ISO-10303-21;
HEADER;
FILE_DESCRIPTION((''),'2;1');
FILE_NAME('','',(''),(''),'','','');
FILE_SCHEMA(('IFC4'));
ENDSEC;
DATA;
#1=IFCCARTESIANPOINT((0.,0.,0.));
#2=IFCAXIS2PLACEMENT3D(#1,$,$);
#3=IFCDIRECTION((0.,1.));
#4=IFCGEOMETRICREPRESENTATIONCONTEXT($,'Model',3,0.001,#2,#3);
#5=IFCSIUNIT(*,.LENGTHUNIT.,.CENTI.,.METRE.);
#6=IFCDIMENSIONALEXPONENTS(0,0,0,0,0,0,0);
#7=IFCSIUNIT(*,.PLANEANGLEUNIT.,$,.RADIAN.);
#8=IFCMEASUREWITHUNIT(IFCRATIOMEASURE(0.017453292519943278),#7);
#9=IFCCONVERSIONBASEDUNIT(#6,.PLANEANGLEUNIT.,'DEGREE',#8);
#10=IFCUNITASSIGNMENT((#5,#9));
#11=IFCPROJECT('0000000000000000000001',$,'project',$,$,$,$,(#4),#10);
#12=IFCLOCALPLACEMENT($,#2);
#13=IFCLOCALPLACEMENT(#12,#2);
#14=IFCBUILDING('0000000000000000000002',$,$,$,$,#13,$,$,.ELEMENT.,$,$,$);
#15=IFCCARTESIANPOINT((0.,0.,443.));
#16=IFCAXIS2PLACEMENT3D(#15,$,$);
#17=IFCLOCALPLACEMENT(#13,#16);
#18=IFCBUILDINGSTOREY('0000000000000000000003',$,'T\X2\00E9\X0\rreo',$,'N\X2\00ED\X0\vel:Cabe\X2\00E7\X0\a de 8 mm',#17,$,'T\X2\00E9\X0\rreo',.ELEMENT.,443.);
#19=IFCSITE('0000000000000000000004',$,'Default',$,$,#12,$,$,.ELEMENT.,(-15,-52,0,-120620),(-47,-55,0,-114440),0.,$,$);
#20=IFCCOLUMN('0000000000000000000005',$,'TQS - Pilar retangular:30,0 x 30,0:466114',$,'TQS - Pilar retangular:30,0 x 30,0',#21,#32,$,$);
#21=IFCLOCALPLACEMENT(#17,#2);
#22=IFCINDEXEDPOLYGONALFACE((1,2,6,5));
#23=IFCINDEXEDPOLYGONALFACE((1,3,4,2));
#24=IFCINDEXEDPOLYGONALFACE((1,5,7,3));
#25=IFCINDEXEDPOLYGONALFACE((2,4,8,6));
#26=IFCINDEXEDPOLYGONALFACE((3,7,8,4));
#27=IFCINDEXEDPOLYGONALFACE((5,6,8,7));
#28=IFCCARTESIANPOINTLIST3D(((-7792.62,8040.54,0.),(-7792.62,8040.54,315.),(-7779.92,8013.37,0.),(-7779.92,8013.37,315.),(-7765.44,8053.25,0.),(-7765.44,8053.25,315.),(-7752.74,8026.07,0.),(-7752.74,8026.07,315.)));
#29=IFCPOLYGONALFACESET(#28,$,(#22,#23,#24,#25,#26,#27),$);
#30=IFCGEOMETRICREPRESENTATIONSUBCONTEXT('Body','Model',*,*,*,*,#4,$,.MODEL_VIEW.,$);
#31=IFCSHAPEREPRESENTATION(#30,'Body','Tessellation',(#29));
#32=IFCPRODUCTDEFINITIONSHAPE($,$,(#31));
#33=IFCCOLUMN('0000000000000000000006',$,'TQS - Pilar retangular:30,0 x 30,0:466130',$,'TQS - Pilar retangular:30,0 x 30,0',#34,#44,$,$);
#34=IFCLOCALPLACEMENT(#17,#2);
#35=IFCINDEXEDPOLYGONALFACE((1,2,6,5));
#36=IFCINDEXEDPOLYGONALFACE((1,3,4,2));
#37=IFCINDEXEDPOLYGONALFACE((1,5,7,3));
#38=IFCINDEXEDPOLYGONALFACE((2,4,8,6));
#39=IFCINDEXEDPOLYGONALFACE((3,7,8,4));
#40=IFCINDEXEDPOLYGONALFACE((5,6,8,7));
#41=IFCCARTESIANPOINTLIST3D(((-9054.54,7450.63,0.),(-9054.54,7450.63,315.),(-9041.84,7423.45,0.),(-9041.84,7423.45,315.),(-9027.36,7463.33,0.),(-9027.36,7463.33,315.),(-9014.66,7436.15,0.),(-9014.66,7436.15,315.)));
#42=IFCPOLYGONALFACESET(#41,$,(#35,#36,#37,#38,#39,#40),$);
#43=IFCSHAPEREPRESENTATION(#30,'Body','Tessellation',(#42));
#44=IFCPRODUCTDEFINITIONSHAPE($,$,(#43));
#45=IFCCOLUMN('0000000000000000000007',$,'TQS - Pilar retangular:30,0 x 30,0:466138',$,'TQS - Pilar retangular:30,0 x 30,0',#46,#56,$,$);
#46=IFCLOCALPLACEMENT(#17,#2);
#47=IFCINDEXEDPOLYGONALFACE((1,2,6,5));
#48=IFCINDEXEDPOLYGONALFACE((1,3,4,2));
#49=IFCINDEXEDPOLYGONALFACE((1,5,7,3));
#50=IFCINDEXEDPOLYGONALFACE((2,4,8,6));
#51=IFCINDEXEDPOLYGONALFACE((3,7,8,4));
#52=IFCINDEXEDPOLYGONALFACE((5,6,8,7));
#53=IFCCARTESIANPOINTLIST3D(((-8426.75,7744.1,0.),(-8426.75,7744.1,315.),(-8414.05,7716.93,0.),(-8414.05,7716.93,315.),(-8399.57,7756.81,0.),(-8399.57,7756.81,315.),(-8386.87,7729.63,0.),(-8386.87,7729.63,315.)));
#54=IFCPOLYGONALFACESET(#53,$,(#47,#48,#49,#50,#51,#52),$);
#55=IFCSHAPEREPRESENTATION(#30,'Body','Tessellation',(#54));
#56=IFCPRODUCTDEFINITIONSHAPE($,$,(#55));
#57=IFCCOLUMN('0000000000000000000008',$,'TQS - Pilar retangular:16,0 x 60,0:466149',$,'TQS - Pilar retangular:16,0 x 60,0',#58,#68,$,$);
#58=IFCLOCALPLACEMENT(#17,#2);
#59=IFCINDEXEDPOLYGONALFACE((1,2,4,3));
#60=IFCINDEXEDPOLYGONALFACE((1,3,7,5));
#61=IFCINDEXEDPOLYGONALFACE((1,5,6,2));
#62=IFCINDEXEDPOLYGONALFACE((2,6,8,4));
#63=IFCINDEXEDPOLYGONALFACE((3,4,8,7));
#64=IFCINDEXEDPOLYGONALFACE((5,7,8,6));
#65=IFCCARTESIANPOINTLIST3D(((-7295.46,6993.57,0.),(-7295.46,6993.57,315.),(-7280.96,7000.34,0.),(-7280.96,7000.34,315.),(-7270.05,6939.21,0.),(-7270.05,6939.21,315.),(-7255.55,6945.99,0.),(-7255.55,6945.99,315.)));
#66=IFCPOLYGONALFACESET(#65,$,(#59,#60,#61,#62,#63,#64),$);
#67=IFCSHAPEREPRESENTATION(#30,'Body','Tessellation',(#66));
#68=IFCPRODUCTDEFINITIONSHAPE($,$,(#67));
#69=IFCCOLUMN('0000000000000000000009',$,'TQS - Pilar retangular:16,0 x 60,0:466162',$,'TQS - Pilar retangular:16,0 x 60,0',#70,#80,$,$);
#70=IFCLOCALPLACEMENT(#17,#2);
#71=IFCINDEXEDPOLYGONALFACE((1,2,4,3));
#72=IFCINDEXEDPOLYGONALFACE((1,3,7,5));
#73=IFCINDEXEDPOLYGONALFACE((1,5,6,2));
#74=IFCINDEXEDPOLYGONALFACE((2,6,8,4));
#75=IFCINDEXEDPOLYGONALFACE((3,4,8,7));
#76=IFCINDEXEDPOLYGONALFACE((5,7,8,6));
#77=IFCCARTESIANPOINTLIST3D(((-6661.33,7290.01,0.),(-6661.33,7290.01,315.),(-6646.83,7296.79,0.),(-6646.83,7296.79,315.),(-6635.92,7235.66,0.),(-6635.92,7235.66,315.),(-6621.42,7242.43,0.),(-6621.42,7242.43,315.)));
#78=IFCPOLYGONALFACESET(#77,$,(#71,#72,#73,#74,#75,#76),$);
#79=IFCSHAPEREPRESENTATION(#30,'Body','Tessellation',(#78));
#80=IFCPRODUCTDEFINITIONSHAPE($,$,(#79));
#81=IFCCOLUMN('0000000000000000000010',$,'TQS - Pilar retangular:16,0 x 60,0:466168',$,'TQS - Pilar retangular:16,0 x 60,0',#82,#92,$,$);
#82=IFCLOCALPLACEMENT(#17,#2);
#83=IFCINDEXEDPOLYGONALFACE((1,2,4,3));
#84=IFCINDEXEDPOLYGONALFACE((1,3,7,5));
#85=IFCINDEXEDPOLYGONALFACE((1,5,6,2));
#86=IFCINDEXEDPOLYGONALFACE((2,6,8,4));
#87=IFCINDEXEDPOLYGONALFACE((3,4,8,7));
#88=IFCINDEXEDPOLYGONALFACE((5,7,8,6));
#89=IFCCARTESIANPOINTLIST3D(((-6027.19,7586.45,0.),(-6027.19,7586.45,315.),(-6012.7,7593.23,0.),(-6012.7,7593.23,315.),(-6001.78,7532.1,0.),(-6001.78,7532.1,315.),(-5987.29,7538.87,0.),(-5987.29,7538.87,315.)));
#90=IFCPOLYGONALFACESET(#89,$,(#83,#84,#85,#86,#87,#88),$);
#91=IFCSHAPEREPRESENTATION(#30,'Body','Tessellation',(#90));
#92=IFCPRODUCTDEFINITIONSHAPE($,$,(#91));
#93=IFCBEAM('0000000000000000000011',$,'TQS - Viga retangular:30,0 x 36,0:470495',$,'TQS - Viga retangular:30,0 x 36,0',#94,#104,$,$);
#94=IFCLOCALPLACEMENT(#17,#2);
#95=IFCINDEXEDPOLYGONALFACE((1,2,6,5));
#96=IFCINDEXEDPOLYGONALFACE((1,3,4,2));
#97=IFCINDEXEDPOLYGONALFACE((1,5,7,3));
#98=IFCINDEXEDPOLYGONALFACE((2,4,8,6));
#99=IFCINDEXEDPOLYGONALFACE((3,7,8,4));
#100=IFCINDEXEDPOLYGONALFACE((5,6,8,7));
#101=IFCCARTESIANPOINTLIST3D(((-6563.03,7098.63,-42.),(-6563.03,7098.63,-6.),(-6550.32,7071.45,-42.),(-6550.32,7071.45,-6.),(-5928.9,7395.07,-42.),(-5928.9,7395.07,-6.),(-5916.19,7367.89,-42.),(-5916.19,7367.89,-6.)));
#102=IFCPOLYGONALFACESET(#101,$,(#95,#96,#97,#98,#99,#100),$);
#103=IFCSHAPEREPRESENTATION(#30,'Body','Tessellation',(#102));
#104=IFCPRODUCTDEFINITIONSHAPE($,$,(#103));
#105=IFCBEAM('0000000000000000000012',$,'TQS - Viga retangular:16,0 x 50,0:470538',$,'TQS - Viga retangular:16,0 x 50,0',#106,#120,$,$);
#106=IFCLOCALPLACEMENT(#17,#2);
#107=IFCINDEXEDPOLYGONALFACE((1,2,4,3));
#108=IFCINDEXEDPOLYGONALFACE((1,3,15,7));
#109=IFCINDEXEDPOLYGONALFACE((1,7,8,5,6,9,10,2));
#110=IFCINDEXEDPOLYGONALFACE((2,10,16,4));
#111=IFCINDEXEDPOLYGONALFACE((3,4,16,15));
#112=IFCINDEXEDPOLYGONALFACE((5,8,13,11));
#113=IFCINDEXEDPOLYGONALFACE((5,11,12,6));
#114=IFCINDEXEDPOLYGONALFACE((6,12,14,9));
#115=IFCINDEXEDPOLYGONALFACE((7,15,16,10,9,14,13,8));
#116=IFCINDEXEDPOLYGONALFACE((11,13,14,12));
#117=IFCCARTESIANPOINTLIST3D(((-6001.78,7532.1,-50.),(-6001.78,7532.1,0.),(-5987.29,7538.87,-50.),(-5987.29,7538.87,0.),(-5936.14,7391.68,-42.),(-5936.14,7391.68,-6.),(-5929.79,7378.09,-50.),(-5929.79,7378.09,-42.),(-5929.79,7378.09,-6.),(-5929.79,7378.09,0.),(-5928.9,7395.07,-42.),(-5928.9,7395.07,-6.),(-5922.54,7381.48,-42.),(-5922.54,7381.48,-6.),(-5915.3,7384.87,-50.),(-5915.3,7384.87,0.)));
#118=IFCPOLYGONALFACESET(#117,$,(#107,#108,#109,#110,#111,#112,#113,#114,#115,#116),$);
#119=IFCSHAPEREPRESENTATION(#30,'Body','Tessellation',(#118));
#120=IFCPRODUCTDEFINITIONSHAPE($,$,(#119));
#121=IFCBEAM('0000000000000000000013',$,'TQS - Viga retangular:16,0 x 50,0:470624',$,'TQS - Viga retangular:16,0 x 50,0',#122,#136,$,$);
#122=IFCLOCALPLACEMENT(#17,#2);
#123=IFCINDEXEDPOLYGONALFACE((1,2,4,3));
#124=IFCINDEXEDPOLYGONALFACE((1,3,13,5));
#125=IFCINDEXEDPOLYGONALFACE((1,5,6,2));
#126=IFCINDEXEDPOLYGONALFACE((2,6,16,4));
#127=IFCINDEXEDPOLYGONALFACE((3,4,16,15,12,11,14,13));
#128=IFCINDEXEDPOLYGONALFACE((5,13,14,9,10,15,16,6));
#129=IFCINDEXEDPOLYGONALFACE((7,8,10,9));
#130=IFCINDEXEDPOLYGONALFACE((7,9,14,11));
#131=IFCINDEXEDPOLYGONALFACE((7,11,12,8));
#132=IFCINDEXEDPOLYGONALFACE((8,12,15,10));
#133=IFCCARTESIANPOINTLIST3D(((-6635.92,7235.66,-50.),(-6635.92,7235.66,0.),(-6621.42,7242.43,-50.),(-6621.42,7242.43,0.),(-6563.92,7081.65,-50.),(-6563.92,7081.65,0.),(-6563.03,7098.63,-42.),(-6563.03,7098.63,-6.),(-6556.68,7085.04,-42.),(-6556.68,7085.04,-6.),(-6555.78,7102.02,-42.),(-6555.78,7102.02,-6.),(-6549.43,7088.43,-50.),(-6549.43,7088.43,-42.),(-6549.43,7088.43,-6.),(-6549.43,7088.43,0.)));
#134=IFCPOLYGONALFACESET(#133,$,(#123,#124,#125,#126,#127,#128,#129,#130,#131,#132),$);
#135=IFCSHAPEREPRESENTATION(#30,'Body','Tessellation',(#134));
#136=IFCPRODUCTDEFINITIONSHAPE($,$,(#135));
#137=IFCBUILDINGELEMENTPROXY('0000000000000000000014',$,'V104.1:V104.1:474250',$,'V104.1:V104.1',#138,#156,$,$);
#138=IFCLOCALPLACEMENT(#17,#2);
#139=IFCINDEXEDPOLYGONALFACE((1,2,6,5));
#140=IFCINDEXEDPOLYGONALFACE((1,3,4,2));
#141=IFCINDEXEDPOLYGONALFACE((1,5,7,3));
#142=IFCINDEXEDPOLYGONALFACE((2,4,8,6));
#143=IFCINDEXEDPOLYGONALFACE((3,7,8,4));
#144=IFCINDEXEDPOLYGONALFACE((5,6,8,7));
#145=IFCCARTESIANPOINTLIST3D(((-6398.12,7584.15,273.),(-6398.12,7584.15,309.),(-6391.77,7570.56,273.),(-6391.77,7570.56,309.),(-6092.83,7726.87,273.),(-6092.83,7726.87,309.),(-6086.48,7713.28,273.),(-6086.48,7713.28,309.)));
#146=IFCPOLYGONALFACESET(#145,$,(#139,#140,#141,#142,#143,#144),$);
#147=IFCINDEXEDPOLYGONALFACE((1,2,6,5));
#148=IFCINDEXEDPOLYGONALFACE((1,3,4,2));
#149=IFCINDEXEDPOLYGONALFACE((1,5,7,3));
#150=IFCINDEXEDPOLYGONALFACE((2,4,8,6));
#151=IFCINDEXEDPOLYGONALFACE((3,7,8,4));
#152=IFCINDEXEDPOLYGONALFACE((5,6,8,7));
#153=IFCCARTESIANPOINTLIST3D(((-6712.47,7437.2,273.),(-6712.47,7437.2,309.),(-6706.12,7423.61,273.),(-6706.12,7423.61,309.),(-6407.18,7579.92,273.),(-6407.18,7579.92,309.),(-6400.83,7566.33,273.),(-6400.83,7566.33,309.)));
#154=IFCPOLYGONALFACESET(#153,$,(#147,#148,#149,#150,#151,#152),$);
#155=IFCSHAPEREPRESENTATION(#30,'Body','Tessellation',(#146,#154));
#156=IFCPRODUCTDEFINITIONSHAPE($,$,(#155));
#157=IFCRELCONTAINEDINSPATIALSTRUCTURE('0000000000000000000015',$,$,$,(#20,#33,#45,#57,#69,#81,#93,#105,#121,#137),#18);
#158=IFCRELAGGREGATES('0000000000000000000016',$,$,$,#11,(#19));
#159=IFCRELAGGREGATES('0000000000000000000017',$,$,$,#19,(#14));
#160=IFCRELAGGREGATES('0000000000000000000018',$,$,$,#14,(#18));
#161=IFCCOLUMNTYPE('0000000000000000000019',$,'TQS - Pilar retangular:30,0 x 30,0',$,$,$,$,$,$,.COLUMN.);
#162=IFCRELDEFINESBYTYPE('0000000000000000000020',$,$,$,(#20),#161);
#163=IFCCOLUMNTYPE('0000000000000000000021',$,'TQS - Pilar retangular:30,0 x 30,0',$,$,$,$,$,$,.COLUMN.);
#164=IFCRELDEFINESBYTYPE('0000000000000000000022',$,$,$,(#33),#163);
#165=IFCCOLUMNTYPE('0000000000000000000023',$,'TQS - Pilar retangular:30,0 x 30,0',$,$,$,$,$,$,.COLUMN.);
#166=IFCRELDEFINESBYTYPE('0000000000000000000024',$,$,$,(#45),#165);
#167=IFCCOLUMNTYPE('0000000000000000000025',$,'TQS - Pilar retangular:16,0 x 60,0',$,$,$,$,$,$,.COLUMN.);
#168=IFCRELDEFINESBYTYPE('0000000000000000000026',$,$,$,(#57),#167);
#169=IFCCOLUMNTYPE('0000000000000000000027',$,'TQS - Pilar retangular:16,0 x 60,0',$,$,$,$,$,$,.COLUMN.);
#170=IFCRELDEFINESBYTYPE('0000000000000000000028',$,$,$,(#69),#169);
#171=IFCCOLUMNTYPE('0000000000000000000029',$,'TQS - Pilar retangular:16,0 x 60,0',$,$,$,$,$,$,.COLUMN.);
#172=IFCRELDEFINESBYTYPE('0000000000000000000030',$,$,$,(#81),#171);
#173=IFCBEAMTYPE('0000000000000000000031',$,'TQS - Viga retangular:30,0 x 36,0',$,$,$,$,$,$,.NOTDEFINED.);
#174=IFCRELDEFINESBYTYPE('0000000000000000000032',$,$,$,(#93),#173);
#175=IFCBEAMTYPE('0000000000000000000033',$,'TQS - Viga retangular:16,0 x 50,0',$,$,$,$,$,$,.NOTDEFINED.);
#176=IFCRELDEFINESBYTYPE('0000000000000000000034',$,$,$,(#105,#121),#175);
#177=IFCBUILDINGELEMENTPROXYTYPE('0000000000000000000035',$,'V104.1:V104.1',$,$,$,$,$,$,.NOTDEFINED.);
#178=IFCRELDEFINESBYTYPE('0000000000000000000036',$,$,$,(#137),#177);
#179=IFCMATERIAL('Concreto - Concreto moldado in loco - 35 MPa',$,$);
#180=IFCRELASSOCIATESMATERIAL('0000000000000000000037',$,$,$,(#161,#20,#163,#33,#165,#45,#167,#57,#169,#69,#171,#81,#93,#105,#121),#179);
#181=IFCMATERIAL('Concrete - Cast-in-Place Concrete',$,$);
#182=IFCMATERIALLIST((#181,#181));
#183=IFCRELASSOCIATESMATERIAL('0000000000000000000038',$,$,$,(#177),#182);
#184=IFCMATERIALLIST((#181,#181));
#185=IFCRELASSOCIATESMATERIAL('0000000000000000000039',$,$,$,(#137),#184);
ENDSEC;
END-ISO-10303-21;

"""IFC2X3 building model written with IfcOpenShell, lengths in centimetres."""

from ifc_helpers import new_model, entity, si_unit, converted_unit, direction, frame, frame_2d, origin, origin_2d_with_axis, place, context, subcontext, project, spatial, polyline, rectangle, extrude, boolean, clip, bounded_halfspace, source, transform, mapped, material, material_list, type_object, type_shapes, element, save


model = new_model("IFC2X3")

# Units and contexts
model_context = context("Model", 3, precision=0.001, world=origin(), true_north=direction((0.0, 1.0)))
body_context = subcontext(model_context, "Body", "Model", "MODEL_VIEW")
ifc_project = project(units=[si_unit("LENGTHUNIT", "METRE", prefix="CENTI"), converted_unit("PLANEANGLEUNIT", "DEGREE", entity("IfcRatioMeasure", 0.017453292519943278), si_unit("PLANEANGLEUNIT", "RADIAN"), dimensions=[0, 0, 0, 0, 0, 0, 0])], contexts=[model_context])

# Site, building, storey
site_placement = place(None, origin())
site = spatial("IfcSite", under=ifc_project, at=site_placement, Name="Default", CompositionType="ELEMENT", RefLatitude=(-15, -52, 0, -120620), RefLongitude=(-47, -55, 0, -114440), RefElevation=0.0)
building_placement = place(site_placement, origin())
building = spatial("IfcBuilding", under=site, at=building_placement, CompositionType="ELEMENT")
storey_placement = place(building_placement, frame((0.0, 0.0, 443.0)))
storey = spatial("IfcBuildingStorey", under=building, at=storey_placement, Name="Térreo", ObjectType="Nível:Cabeça de 8 mm", LongName="Térreo", CompositionType="ELEMENT", Elevation=443.0)

# Columns
ifc_material_1 = material(Name="Concreto - Concreto moldado in loco - 35 MPa")
column_type_1 = type_object("IfcColumnType", Name="TQS - Pilar retangular:30,0 x 30,0", PredefinedType="COLUMN", material=ifc_material_1)
shared_shape_1 = source(origin(), body_context, "Body", "SweptSolid", [
    extrude(rectangle(XDim=30.0, YDim=30.0, at=origin_2d_with_axis()), frame((-7772.68, 8033.31, 443.0), z_axis=(0.0, 0.0, 1.0), x_axis=(-0.423488, 0.905902, 0.0)), (0.0, 0.0, 1.0), 315.0),
])
type_shapes(column_type_1, [shared_shape_1])
column_1_placement = place(storey_placement, frame((0.0, 0.0, -443.0)))
element("IfcColumn", 1, at=column_1_placement, inside=storey, type_object=column_type_1, material=ifc_material_1, Name="TQS - Pilar retangular:30,0 x 30,0:466114", ObjectType="TQS - Pilar retangular:30,0 x 30,0", context=body_context, shape_type="MappedRepresentation", body=[
    mapped(shared_shape_1, transform((0.0, 0.0, 0.0), scale=1.0)),
])
column_type_2 = type_object("IfcColumnType", Name="TQS - Pilar retangular:30,0 x 30,0", PredefinedType="COLUMN", material=ifc_material_1)
shared_shape_2 = source(origin(), body_context, "Body", "SweptSolid", [
    extrude(rectangle(XDim=30.0, YDim=30.0, at=origin_2d_with_axis()), frame((-9034.6, 7443.39, 443.0), z_axis=(0.0, 0.0, 1.0), x_axis=(-0.423488, 0.905902, 0.0)), (0.0, 0.0, 1.0), 315.0),
])
type_shapes(column_type_2, [shared_shape_2])
column_2_placement = place(storey_placement, frame((0.0, 0.0, -443.0)))
element("IfcColumn", 2, at=column_2_placement, inside=storey, type_object=column_type_2, material=ifc_material_1, Name="TQS - Pilar retangular:30,0 x 30,0:466130", ObjectType="TQS - Pilar retangular:30,0 x 30,0", context=body_context, shape_type="MappedRepresentation", body=[
    mapped(shared_shape_2, transform((0.0, 0.0, 0.0), scale=1.0)),
])
column_type_3 = type_object("IfcColumnType", Name="TQS - Pilar retangular:30,0 x 30,0", PredefinedType="COLUMN", material=ifc_material_1)
shared_shape_3 = source(origin(), body_context, "Body", "SweptSolid", [
    extrude(rectangle(XDim=30.0, YDim=30.0, at=origin_2d_with_axis()), frame((-8406.81, 7736.87, 443.0), z_axis=(0.0, 0.0, 1.0), x_axis=(-0.423488, 0.905902, 0.0)), (0.0, 0.0, 1.0), 315.0),
])
type_shapes(column_type_3, [shared_shape_3])
column_3_placement = place(storey_placement, frame((0.0, 0.0, -443.0)))
element("IfcColumn", 3, at=column_3_placement, inside=storey, type_object=column_type_3, material=ifc_material_1, Name="TQS - Pilar retangular:30,0 x 30,0:466138", ObjectType="TQS - Pilar retangular:30,0 x 30,0", context=body_context, shape_type="MappedRepresentation", body=[
    mapped(shared_shape_3, transform((0.0, 0.0, 0.0), scale=1.0)),
])
column_type_4 = type_object("IfcColumnType", Name="TQS - Pilar retangular:16,0 x 60,0", PredefinedType="COLUMN", material=ifc_material_1)
shared_shape_4 = source(origin(), body_context, "Body", "SweptSolid", [
    extrude(rectangle(XDim=60.0, YDim=16.0, at=frame_2d((0.0, 0.0), x_axis=(1.0, 0.0))), frame((-7275.5, 6969.78, 443.0), z_axis=(0.0, 0.0, 1.0), x_axis=(-0.423488, 0.905902, 0.0)), (0.0, 0.0, 1.0), 315.0),
])
type_shapes(column_type_4, [shared_shape_4])
column_4_placement = place(storey_placement, frame((0.0, 0.0, -443.0)))
element("IfcColumn", 4, at=column_4_placement, inside=storey, type_object=column_type_4, material=ifc_material_1, Name="TQS - Pilar retangular:16,0 x 60,0:466149", ObjectType="TQS - Pilar retangular:16,0 x 60,0", context=body_context, shape_type="MappedRepresentation", body=[
    mapped(shared_shape_4, transform((0.0, 0.0, 0.0), scale=1.0)),
])
column_type_5 = type_object("IfcColumnType", Name="TQS - Pilar retangular:16,0 x 60,0", PredefinedType="COLUMN", material=ifc_material_1)
shared_shape_5 = source(origin(), body_context, "Body", "SweptSolid", [
    extrude(rectangle(XDim=60.0, YDim=16.0, at=frame_2d((0.0, 0.0), x_axis=(1.0, 0.0))), frame((-6641.37, 7266.22, 443.0), z_axis=(0.0, 0.0, 1.0), x_axis=(-0.423488, 0.905902, 0.0)), (0.0, 0.0, 1.0), 315.0),
])
type_shapes(column_type_5, [shared_shape_5])
column_5_placement = place(storey_placement, frame((0.0, 0.0, -443.0)))
element("IfcColumn", 5, at=column_5_placement, inside=storey, type_object=column_type_5, material=ifc_material_1, Name="TQS - Pilar retangular:16,0 x 60,0:466162", ObjectType="TQS - Pilar retangular:16,0 x 60,0", context=body_context, shape_type="MappedRepresentation", body=[
    mapped(shared_shape_5, transform((0.0, 0.0, 0.0), scale=1.0)),
])
column_type_6 = type_object("IfcColumnType", Name="TQS - Pilar retangular:16,0 x 60,0", PredefinedType="COLUMN", material=ifc_material_1)
shared_shape_6 = source(origin(), body_context, "Body", "SweptSolid", [
    extrude(rectangle(XDim=60.0, YDim=16.0, at=origin_2d_with_axis()), frame((-6007.24, 7562.66, 443.0), z_axis=(0.0, 0.0, 1.0), x_axis=(-0.423488, 0.905902, 0.0)), (0.0, 0.0, 1.0), 315.0),
])
type_shapes(column_type_6, [shared_shape_6])
column_6_placement = place(storey_placement, frame((0.0, 0.0, -443.0)))
element("IfcColumn", 6, at=column_6_placement, inside=storey, type_object=column_type_6, material=ifc_material_1, Name="TQS - Pilar retangular:16,0 x 60,0:466168", ObjectType="TQS - Pilar retangular:16,0 x 60,0", context=body_context, shape_type="MappedRepresentation", body=[
    mapped(shared_shape_6, transform((0.0, 0.0, 0.0), scale=1.0)),
])

# Beams
beam_type_1 = type_object("IfcBeamType", Name="TQS - Viga retangular:30,0 x 36,0", PredefinedType="NOTDEFINED")
beam_1_placement = place(storey_placement, frame((-6556.68, 7085.04, -6.0), z_axis=(0.0, 0.0, 1.0), x_axis=(0.905902, 0.423488, 0.0)))
element("IfcBeam", 7, at=beam_1_placement, inside=storey, type_object=beam_type_1, material=ifc_material_1, Name="TQS - Viga retangular:30,0 x 36,0:470495", ObjectType="TQS - Viga retangular:30,0 x 36,0", context=body_context, shape_type="SweptSolid", body=[
    extrude(rectangle(XDim=36.0, YDim=30.0, at=frame_2d((0.0, 0.0), x_axis=(1.0, 0.0))), frame((0.0, 0.0, -18.0), z_axis=(1.0, 0.0, 0.0), x_axis=(0.0, 0.0, -1.0)), (0.0, 0.0, 1.0), 700.0),
])
beam_type_2 = type_object("IfcBeamType", Name="TQS - Viga retangular:16,0 x 50,0", PredefinedType="NOTDEFINED")
beam_2_placement = place(storey_placement, frame((-5922.54, 7381.48, 0.0), z_axis=(0.0, 0.0, 1.0), x_axis=(-0.423488, 0.905902, 0.0)))
element("IfcBeam", 8, at=beam_2_placement, inside=storey, type_object=beam_type_2, material=ifc_material_1, Name="TQS - Viga retangular:16,0 x 50,0:470538", ObjectType="TQS - Viga retangular:16,0 x 50,0", context=body_context, shape_type="SweptSolid", body=[
    boolean("DIFFERENCE", clip(extrude(rectangle(XDim=50.0, YDim=16.0, at=frame_2d((0.0, 0.0), x_axis=(1.0, 0.0))), frame((0.0, 0.0, -25.0), z_axis=(1.0, 0.0, 0.0), x_axis=(0.0, 0.0, -1.0)), (0.0, 0.0, 1.0), 170.0), bounded_halfspace(frame((15.0, 0.0, -42.0), z_axis=(-1.0, 0.0, 0.0), x_axis=(0.0, 1.0, 0.0)), False, frame((0.0, 0.0, -25.0), z_axis=(1.0, 0.0, 0.0), x_axis=(0.0, 0.0, -1.0)), polyline([(17.0, 0.0), (-19.0, 0.0), (-19.0, 8.0), (-9.0, 8.0), (17.0, 8.0), (17.0, 0.0)]))), extrude(rectangle(XDim=36.0, YDim=8.0, at=frame_2d((0.0, 0.0), x_axis=(0.0, 1.0))), frame((0.0, 4.0, -24.0), z_axis=(-1.0, 0.0, 0.0), x_axis=(0.0, -1.0, 0.0)), (0.0, 0.0, -1.0), 15.0)),
])
beam_3_placement = place(storey_placement, frame((-6556.68, 7085.04, 0.0), z_axis=(0.0, 0.0, 1.0), x_axis=(-0.423488, 0.905902, 0.0)))
element("IfcBeam", 9, at=beam_3_placement, inside=storey, type_object=beam_type_2, material=ifc_material_1, Name="TQS - Viga retangular:16,0 x 50,0:470624", ObjectType="TQS - Viga retangular:16,0 x 50,0", context=body_context, shape_type="SweptSolid", body=[
    boolean("DIFFERENCE", clip(extrude(rectangle(XDim=50.0, YDim=16.0, at=frame_2d((0.0, 0.0), x_axis=(0.0, 1.0))), frame((0.0, 0.0, -25.0), z_axis=(1.0, 0.0, 0.0), x_axis=(0.0, 1.0, 0.0)), (0.0, 0.0, 1.0), 170.0), bounded_halfspace(frame((15.0, -700.0, -42.0), z_axis=(-1.0, 0.0, 0.0), x_axis=(0.0, 1.0, 0.0)), False, frame((0.0, 0.0, -25.0), z_axis=(1.0, 0.0, 0.0), x_axis=(0.0, 1.0, 0.0)), polyline([(0.0, 19.0), (0.0, -17.0), (-8.0, -17.0), (-8.0, 9.0), (-8.0, 19.0), (0.0, 19.0)]))), extrude(rectangle(XDim=36.0, YDim=8.0, at=frame_2d((0.0, 0.0), x_axis=(0.0, 1.0))), frame((15.0, -4.0, -24.0), z_axis=(1.0, 0.0, 0.0), x_axis=(0.0, 1.0, 0.0)), (0.0, 0.0, -1.0), 15.0)),
])

# Building element proxy
ifc_material_2 = material(Name="Concrete - Cast-in-Place Concrete")
ifc_material_list_1 = material_list([ifc_material_2, ifc_material_2])
ifc_material_list_2 = material_list([ifc_material_2, ifc_material_2])
building_element_proxy_type_1 = type_object("IfcBuildingElementProxyType", Name="V104.1:V104.1", PredefinedType="NOTDEFINED", material=ifc_material_list_2)
shared_shape_7 = source(origin(), body_context, "Body", "SweptSolid", [
    extrude(rectangle(XDim=15.0, YDim=337.0, at=frame_2d((0.0, 0.0), x_axis=(1.0, 0.0))), frame((470.17, 225.1, 0.0), z_axis=(0.0, 0.0, 1.0), x_axis=(-0.423488, 0.905902, 0.0)), (0.0, 0.0, 1.0), 36.0),
    extrude(rectangle(XDim=337.0, YDim=15.0, at=frame_2d((0.0, 0.0), x_axis=(1.0, 0.0))), frame((155.82, 78.15, 0.0), z_axis=(0.0, 0.0, 1.0), x_axis=(-0.905902, -0.423488, 0.0)), (0.0, 0.0, 1.0), 36.0),
])
type_shapes(building_element_proxy_type_1, [shared_shape_7])
proxy_1_placement = place(storey_placement, frame((-6712.47, 7423.61, 273.0)))
element("IfcBuildingElementProxy", 10, at=proxy_1_placement, inside=storey, type_object=building_element_proxy_type_1, material=ifc_material_list_1, Name="V104.1:V104.1:474250", ObjectType="V104.1:V104.1", context=body_context, shape_type="MappedRepresentation", body=[
    mapped(shared_shape_7, transform((0.0, 0.0, 0.0), scale=1.0)),
])

save(model, "model.ifc")
